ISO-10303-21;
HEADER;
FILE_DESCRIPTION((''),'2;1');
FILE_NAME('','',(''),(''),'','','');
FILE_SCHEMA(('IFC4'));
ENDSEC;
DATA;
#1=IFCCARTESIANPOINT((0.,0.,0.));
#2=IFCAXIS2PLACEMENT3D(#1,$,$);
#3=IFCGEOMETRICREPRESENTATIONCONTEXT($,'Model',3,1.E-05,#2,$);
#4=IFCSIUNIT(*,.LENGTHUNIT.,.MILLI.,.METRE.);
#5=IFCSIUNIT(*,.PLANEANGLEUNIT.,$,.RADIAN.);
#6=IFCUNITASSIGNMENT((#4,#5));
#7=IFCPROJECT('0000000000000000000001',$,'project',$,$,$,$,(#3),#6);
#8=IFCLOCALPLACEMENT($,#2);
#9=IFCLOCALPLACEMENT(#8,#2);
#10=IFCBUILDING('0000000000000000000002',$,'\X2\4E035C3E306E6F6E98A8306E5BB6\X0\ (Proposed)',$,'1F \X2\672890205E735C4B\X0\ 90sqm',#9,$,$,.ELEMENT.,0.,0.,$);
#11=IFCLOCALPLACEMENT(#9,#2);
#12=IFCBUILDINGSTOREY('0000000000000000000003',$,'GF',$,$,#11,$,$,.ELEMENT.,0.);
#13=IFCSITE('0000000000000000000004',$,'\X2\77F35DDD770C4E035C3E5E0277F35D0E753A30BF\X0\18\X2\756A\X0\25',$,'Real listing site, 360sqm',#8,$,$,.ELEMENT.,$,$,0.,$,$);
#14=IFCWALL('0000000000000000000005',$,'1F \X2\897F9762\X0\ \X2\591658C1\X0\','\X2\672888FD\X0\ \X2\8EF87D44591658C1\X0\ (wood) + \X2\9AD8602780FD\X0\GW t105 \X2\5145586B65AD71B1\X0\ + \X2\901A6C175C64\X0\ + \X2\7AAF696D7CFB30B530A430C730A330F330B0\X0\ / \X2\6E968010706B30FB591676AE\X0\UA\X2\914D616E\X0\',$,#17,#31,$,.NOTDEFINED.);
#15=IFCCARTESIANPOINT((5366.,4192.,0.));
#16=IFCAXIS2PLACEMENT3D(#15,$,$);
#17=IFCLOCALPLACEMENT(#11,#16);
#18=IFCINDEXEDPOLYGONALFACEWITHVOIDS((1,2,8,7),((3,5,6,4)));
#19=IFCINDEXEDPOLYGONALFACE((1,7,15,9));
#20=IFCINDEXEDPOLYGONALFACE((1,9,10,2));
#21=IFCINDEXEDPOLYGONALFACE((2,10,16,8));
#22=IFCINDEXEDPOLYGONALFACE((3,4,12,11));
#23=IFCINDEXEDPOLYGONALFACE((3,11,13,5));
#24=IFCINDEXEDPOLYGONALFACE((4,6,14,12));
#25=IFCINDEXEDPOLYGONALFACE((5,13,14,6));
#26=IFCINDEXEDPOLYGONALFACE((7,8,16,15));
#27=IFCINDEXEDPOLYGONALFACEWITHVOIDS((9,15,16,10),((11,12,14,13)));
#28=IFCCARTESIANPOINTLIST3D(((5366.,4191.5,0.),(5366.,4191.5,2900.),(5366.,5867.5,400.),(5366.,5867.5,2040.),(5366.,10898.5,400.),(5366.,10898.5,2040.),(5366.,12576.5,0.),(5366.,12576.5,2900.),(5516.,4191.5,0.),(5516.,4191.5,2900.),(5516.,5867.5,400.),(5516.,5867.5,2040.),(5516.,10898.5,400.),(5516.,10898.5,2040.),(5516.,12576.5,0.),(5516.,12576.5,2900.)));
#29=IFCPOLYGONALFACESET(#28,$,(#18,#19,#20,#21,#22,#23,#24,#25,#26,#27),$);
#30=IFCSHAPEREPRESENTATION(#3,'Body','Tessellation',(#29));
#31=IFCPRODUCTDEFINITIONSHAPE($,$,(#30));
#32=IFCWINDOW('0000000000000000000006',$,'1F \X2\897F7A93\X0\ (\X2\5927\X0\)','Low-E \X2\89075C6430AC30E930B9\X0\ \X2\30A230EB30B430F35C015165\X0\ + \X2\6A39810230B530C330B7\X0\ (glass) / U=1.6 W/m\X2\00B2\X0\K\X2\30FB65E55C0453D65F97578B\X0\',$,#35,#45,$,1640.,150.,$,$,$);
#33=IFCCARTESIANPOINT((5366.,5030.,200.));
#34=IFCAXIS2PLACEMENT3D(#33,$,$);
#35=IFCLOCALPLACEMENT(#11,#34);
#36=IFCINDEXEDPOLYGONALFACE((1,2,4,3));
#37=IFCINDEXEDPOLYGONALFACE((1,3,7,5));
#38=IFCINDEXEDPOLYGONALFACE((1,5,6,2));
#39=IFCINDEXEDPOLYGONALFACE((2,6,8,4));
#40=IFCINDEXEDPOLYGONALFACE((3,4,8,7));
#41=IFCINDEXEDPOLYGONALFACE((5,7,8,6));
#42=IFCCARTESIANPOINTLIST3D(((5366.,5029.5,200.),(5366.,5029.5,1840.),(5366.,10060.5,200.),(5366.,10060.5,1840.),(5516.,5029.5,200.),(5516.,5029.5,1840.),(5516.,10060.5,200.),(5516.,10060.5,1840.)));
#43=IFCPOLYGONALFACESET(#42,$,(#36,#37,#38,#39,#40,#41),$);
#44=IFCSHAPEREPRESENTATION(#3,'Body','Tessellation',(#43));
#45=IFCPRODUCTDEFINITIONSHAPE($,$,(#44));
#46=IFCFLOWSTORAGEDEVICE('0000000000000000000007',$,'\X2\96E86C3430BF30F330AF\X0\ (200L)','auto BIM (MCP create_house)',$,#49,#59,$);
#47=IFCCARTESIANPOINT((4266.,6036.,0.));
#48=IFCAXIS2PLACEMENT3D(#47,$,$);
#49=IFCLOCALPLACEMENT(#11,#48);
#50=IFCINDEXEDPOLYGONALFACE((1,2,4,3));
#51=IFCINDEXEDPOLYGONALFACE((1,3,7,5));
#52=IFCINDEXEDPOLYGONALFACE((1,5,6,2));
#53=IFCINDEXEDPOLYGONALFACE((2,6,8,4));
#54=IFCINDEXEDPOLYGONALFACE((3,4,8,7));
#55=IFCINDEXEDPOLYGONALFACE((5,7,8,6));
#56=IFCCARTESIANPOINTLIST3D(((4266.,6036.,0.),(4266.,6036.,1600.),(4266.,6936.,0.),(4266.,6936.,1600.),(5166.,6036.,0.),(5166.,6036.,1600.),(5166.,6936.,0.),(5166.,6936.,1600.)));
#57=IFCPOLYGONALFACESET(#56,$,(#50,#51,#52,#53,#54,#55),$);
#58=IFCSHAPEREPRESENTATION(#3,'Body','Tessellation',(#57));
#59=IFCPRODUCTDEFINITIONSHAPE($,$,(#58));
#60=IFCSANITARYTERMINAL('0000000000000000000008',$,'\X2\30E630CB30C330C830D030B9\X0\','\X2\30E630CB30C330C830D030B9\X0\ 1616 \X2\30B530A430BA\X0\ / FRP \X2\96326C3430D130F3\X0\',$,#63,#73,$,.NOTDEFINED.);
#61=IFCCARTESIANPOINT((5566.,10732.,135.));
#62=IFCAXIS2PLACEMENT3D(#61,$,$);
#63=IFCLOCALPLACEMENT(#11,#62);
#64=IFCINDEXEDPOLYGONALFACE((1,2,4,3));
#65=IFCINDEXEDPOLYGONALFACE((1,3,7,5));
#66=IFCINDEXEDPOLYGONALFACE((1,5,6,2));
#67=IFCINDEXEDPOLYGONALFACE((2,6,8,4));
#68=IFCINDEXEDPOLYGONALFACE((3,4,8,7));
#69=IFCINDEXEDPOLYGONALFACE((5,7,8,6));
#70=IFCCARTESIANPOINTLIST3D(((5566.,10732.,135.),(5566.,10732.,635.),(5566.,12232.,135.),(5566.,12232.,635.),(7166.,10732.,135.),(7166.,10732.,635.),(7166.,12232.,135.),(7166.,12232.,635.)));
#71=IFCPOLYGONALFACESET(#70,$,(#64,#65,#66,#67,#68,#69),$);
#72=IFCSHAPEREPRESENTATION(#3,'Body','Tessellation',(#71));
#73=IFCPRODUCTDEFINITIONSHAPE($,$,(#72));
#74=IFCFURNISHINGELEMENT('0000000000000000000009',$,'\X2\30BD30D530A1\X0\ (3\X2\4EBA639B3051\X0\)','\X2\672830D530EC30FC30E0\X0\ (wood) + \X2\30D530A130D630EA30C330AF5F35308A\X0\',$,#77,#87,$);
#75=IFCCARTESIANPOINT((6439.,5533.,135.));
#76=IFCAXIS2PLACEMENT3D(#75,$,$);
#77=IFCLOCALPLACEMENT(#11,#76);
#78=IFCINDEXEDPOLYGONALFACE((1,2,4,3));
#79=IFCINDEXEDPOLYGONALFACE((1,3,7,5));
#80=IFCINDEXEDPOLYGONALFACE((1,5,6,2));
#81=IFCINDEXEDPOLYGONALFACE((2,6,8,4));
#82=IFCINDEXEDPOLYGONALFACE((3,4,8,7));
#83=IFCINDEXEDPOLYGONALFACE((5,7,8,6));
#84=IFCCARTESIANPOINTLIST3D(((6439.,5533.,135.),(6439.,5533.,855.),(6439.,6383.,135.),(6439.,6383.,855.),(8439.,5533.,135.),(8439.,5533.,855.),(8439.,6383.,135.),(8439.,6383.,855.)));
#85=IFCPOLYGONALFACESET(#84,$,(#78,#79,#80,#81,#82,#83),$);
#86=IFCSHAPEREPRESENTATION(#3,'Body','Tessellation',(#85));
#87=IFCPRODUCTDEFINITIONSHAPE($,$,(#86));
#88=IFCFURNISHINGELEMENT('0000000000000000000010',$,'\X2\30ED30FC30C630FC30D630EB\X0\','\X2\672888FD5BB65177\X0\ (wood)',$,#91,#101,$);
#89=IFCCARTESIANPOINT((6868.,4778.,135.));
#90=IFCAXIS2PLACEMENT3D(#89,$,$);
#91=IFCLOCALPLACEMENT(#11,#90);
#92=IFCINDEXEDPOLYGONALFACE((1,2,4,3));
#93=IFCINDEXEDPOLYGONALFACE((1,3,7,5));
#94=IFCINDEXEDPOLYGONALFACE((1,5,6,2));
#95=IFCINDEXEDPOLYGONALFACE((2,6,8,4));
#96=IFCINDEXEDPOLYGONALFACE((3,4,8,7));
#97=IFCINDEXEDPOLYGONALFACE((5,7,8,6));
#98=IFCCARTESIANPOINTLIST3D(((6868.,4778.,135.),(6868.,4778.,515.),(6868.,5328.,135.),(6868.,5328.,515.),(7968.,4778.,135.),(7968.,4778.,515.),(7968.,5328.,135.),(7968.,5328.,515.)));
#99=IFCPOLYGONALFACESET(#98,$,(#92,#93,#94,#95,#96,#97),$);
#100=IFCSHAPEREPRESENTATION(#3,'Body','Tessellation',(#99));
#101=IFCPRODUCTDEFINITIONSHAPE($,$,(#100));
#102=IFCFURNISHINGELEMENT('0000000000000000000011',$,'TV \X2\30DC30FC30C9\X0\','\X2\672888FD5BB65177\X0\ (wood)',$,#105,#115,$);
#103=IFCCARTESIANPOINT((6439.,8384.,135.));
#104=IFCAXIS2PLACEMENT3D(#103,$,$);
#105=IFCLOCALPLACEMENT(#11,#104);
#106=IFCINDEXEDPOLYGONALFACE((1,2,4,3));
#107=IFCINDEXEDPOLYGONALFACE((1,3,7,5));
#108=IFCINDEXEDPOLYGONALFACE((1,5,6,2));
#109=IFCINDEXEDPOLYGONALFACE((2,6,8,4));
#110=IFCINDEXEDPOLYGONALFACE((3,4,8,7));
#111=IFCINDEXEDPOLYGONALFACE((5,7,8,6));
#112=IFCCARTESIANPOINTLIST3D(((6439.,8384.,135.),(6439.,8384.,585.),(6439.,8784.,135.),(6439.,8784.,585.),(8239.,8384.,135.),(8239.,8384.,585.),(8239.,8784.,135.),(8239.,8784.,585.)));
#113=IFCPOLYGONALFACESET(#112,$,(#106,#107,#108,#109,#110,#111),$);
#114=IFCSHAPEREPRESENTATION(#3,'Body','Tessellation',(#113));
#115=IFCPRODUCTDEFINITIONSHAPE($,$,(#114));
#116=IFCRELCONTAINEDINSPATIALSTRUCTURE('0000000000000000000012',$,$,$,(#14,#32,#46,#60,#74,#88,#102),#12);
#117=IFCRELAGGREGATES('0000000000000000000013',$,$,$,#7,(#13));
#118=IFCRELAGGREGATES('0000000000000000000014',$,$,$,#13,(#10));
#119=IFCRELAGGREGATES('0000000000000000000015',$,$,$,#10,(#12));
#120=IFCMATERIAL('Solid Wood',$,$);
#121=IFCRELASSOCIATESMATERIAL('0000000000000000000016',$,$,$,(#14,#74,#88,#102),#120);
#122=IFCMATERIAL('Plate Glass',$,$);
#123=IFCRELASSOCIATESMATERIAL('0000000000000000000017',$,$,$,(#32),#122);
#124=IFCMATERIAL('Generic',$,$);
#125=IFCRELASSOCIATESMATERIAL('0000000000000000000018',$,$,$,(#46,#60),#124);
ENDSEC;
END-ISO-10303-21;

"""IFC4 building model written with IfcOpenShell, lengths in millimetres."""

from ifc_helpers import new_model, si_unit, frame, frame_2d, origin, place, context, project, spatial, rectangle, extrude, material, element, fill, save


model = new_model("IFC4")

# Units and contexts
model_context = context("Model", 3, precision=1e-05, world=origin())
ifc_project = project(units=[si_unit("LENGTHUNIT", "METRE", prefix="MILLI"), si_unit("PLANEANGLEUNIT", "RADIAN")], contexts=[model_context])

# Site, building, storey
site_placement = place(None, origin())
site = spatial("IfcSite", under=ifc_project, at=site_placement, Name="石川県七尾市石崎町タ18番25", ObjectType="Real listing site, 360sqm", CompositionType="ELEMENT", RefElevation=0.0)
building_placement = place(site_placement, origin())
building = spatial("IfcBuilding", under=site, at=building_placement, Name="七尾の潮風の家 (Proposed)", ObjectType="1F 木造平屋 90sqm", CompositionType="ELEMENT", ElevationOfRefHeight=0.0, ElevationOfTerrain=0.0)
storey_placement = place(building_placement, origin())
storey = spatial("IfcBuildingStorey", under=building, at=storey_placement, Name="GF", CompositionType="ELEMENT", Elevation=0.0)

# Shared definitions
ifc_material_1 = material(Name="Solid Wood")

# Shared definitions
ifc_material_2 = material(Name="Plate Glass")

# Wall, opening, window
wall_1_placement = place(storey_placement, frame((5366.0, 4192.0, 0.0)))
wall_1 = element("IfcWall", 1, at=wall_1_placement, inside=storey, material=ifc_material_1, Name="1F 西面 外壁", Description="木製 軸組外壁 (wood) + 高性能GW t105 充填断熱 + 通気層 + 窯業系サイディング / 準耐火・外皮UA配慮", PredefinedType="NOTDEFINED", context=model_context, shape_type="SweptSolid", body=[
    extrude(rectangle(XDim=150.0, YDim=8385.0, at=frame_2d((75.0, 4192.0))), frame((5366.0, 4192.0, 0.0)), (0.0, 0.0, 1.0), 2900.0),
])
opening_1_placement = place(storey_placement, frame((5366.0, 5030.0, 200.0)))
opening_1 = element("IfcOpeningElement", 2, at=opening_1_placement, cuts=wall_1, PredefinedType="NOTDEFINED", context=model_context, shape_type="SweptSolid", body=[
    extrude(rectangle(XDim=150.0, YDim=5031.0, at=frame_2d((75.0, 2515.0))), frame((5366.0, 5030.0, 200.0)), (0.0, 0.0, 1.0), 1640.0),
])
window_1_placement = place(storey_placement, frame((5366.0, 5030.0, 200.0)))
window_1 = element("IfcWindow", 3, at=window_1_placement, inside=storey, material=ifc_material_2, Name="1F 西窓 (大)", Description="Low-E 複層ガラス アルゴン封入 + 樹脂サッシ (glass) / U=1.6 W/m²K・日射取得型", OverallHeight=1640.0, OverallWidth=150.0, context=model_context, shape_type="SweptSolid", body=[
    extrude(rectangle(XDim=150.0, YDim=5031.0, at=frame_2d((75.0, 2515.0))), frame((5366.0, 5030.0, 200.0)), (0.0, 0.0, 1.0), 1640.0),
])
fill(opening_1, window_1)

# Shared definitions
ifc_material_3 = material(Name="Generic")

# Flow storage device
flow_storage_device_placement = place(storey_placement, frame((4266.0, 6036.0, 0.0)))
element("IfcFlowStorageDevice", 4, at=flow_storage_device_placement, inside=storey, material=ifc_material_3, Name="雨水タンク (200L)", Description="auto BIM (MCP create_house)", context=model_context, shape_type="SweptSolid", body=[
    extrude(rectangle(XDim=900.0, YDim=900.0, at=frame_2d((450.0, 450.0))), frame((4266.0, 6036.0, 0.0)), (0.0, 0.0, 1.0), 1600.0),
])

# Sanitary terminal
sanitary_terminal_placement = place(storey_placement, frame((5566.0, 10732.0, 135.0)))
element("IfcSanitaryTerminal", 5, at=sanitary_terminal_placement, inside=storey, material=ifc_material_3, Name="ユニットバス", Description="ユニットバス 1616 サイズ / FRP 防水パン", PredefinedType="NOTDEFINED", context=model_context, shape_type="SweptSolid", body=[
    extrude(rectangle(XDim=1600.0, YDim=1500.0, at=frame_2d((800.0, 750.0))), frame((5566.0, 10732.0, 135.0)), (0.0, 0.0, 1.0), 500.0),
])

# Furnishing elements
furnishing_1_placement = place(storey_placement, frame((6439.0, 5533.0, 135.0)))
element("IfcFurnishingElement", 6, at=furnishing_1_placement, inside=storey, material=ifc_material_1, Name="ソファ (3人掛け)", Description="木フレーム (wood) + ファブリック張り", context=model_context, shape_type="SweptSolid", body=[
    extrude(rectangle(XDim=2000.0, YDim=850.0, at=frame_2d((1000.0, 425.0))), frame((6439.0, 5533.0, 135.0)), (0.0, 0.0, 1.0), 720.0),
])
furnishing_2_placement = place(storey_placement, frame((6868.0, 4778.0, 135.0)))
element("IfcFurnishingElement", 7, at=furnishing_2_placement, inside=storey, material=ifc_material_1, Name="ローテーブル", Description="木製家具 (wood)", context=model_context, shape_type="SweptSolid", body=[
    extrude(rectangle(XDim=1100.0, YDim=550.0, at=frame_2d((550.0, 275.0))), frame((6868.0, 4778.0, 135.0)), (0.0, 0.0, 1.0), 380.0),
])
furnishing_3_placement = place(storey_placement, frame((6439.0, 8384.0, 135.0)))
element("IfcFurnishingElement", 8, at=furnishing_3_placement, inside=storey, material=ifc_material_1, Name="TV ボード", Description="木製家具 (wood)", context=model_context, shape_type="SweptSolid", body=[
    extrude(rectangle(XDim=1800.0, YDim=400.0, at=frame_2d((900.0, 200.0))), frame((6439.0, 8384.0, 135.0)), (0.0, 0.0, 1.0), 450.0),
])

save(model, "model.ifc")
